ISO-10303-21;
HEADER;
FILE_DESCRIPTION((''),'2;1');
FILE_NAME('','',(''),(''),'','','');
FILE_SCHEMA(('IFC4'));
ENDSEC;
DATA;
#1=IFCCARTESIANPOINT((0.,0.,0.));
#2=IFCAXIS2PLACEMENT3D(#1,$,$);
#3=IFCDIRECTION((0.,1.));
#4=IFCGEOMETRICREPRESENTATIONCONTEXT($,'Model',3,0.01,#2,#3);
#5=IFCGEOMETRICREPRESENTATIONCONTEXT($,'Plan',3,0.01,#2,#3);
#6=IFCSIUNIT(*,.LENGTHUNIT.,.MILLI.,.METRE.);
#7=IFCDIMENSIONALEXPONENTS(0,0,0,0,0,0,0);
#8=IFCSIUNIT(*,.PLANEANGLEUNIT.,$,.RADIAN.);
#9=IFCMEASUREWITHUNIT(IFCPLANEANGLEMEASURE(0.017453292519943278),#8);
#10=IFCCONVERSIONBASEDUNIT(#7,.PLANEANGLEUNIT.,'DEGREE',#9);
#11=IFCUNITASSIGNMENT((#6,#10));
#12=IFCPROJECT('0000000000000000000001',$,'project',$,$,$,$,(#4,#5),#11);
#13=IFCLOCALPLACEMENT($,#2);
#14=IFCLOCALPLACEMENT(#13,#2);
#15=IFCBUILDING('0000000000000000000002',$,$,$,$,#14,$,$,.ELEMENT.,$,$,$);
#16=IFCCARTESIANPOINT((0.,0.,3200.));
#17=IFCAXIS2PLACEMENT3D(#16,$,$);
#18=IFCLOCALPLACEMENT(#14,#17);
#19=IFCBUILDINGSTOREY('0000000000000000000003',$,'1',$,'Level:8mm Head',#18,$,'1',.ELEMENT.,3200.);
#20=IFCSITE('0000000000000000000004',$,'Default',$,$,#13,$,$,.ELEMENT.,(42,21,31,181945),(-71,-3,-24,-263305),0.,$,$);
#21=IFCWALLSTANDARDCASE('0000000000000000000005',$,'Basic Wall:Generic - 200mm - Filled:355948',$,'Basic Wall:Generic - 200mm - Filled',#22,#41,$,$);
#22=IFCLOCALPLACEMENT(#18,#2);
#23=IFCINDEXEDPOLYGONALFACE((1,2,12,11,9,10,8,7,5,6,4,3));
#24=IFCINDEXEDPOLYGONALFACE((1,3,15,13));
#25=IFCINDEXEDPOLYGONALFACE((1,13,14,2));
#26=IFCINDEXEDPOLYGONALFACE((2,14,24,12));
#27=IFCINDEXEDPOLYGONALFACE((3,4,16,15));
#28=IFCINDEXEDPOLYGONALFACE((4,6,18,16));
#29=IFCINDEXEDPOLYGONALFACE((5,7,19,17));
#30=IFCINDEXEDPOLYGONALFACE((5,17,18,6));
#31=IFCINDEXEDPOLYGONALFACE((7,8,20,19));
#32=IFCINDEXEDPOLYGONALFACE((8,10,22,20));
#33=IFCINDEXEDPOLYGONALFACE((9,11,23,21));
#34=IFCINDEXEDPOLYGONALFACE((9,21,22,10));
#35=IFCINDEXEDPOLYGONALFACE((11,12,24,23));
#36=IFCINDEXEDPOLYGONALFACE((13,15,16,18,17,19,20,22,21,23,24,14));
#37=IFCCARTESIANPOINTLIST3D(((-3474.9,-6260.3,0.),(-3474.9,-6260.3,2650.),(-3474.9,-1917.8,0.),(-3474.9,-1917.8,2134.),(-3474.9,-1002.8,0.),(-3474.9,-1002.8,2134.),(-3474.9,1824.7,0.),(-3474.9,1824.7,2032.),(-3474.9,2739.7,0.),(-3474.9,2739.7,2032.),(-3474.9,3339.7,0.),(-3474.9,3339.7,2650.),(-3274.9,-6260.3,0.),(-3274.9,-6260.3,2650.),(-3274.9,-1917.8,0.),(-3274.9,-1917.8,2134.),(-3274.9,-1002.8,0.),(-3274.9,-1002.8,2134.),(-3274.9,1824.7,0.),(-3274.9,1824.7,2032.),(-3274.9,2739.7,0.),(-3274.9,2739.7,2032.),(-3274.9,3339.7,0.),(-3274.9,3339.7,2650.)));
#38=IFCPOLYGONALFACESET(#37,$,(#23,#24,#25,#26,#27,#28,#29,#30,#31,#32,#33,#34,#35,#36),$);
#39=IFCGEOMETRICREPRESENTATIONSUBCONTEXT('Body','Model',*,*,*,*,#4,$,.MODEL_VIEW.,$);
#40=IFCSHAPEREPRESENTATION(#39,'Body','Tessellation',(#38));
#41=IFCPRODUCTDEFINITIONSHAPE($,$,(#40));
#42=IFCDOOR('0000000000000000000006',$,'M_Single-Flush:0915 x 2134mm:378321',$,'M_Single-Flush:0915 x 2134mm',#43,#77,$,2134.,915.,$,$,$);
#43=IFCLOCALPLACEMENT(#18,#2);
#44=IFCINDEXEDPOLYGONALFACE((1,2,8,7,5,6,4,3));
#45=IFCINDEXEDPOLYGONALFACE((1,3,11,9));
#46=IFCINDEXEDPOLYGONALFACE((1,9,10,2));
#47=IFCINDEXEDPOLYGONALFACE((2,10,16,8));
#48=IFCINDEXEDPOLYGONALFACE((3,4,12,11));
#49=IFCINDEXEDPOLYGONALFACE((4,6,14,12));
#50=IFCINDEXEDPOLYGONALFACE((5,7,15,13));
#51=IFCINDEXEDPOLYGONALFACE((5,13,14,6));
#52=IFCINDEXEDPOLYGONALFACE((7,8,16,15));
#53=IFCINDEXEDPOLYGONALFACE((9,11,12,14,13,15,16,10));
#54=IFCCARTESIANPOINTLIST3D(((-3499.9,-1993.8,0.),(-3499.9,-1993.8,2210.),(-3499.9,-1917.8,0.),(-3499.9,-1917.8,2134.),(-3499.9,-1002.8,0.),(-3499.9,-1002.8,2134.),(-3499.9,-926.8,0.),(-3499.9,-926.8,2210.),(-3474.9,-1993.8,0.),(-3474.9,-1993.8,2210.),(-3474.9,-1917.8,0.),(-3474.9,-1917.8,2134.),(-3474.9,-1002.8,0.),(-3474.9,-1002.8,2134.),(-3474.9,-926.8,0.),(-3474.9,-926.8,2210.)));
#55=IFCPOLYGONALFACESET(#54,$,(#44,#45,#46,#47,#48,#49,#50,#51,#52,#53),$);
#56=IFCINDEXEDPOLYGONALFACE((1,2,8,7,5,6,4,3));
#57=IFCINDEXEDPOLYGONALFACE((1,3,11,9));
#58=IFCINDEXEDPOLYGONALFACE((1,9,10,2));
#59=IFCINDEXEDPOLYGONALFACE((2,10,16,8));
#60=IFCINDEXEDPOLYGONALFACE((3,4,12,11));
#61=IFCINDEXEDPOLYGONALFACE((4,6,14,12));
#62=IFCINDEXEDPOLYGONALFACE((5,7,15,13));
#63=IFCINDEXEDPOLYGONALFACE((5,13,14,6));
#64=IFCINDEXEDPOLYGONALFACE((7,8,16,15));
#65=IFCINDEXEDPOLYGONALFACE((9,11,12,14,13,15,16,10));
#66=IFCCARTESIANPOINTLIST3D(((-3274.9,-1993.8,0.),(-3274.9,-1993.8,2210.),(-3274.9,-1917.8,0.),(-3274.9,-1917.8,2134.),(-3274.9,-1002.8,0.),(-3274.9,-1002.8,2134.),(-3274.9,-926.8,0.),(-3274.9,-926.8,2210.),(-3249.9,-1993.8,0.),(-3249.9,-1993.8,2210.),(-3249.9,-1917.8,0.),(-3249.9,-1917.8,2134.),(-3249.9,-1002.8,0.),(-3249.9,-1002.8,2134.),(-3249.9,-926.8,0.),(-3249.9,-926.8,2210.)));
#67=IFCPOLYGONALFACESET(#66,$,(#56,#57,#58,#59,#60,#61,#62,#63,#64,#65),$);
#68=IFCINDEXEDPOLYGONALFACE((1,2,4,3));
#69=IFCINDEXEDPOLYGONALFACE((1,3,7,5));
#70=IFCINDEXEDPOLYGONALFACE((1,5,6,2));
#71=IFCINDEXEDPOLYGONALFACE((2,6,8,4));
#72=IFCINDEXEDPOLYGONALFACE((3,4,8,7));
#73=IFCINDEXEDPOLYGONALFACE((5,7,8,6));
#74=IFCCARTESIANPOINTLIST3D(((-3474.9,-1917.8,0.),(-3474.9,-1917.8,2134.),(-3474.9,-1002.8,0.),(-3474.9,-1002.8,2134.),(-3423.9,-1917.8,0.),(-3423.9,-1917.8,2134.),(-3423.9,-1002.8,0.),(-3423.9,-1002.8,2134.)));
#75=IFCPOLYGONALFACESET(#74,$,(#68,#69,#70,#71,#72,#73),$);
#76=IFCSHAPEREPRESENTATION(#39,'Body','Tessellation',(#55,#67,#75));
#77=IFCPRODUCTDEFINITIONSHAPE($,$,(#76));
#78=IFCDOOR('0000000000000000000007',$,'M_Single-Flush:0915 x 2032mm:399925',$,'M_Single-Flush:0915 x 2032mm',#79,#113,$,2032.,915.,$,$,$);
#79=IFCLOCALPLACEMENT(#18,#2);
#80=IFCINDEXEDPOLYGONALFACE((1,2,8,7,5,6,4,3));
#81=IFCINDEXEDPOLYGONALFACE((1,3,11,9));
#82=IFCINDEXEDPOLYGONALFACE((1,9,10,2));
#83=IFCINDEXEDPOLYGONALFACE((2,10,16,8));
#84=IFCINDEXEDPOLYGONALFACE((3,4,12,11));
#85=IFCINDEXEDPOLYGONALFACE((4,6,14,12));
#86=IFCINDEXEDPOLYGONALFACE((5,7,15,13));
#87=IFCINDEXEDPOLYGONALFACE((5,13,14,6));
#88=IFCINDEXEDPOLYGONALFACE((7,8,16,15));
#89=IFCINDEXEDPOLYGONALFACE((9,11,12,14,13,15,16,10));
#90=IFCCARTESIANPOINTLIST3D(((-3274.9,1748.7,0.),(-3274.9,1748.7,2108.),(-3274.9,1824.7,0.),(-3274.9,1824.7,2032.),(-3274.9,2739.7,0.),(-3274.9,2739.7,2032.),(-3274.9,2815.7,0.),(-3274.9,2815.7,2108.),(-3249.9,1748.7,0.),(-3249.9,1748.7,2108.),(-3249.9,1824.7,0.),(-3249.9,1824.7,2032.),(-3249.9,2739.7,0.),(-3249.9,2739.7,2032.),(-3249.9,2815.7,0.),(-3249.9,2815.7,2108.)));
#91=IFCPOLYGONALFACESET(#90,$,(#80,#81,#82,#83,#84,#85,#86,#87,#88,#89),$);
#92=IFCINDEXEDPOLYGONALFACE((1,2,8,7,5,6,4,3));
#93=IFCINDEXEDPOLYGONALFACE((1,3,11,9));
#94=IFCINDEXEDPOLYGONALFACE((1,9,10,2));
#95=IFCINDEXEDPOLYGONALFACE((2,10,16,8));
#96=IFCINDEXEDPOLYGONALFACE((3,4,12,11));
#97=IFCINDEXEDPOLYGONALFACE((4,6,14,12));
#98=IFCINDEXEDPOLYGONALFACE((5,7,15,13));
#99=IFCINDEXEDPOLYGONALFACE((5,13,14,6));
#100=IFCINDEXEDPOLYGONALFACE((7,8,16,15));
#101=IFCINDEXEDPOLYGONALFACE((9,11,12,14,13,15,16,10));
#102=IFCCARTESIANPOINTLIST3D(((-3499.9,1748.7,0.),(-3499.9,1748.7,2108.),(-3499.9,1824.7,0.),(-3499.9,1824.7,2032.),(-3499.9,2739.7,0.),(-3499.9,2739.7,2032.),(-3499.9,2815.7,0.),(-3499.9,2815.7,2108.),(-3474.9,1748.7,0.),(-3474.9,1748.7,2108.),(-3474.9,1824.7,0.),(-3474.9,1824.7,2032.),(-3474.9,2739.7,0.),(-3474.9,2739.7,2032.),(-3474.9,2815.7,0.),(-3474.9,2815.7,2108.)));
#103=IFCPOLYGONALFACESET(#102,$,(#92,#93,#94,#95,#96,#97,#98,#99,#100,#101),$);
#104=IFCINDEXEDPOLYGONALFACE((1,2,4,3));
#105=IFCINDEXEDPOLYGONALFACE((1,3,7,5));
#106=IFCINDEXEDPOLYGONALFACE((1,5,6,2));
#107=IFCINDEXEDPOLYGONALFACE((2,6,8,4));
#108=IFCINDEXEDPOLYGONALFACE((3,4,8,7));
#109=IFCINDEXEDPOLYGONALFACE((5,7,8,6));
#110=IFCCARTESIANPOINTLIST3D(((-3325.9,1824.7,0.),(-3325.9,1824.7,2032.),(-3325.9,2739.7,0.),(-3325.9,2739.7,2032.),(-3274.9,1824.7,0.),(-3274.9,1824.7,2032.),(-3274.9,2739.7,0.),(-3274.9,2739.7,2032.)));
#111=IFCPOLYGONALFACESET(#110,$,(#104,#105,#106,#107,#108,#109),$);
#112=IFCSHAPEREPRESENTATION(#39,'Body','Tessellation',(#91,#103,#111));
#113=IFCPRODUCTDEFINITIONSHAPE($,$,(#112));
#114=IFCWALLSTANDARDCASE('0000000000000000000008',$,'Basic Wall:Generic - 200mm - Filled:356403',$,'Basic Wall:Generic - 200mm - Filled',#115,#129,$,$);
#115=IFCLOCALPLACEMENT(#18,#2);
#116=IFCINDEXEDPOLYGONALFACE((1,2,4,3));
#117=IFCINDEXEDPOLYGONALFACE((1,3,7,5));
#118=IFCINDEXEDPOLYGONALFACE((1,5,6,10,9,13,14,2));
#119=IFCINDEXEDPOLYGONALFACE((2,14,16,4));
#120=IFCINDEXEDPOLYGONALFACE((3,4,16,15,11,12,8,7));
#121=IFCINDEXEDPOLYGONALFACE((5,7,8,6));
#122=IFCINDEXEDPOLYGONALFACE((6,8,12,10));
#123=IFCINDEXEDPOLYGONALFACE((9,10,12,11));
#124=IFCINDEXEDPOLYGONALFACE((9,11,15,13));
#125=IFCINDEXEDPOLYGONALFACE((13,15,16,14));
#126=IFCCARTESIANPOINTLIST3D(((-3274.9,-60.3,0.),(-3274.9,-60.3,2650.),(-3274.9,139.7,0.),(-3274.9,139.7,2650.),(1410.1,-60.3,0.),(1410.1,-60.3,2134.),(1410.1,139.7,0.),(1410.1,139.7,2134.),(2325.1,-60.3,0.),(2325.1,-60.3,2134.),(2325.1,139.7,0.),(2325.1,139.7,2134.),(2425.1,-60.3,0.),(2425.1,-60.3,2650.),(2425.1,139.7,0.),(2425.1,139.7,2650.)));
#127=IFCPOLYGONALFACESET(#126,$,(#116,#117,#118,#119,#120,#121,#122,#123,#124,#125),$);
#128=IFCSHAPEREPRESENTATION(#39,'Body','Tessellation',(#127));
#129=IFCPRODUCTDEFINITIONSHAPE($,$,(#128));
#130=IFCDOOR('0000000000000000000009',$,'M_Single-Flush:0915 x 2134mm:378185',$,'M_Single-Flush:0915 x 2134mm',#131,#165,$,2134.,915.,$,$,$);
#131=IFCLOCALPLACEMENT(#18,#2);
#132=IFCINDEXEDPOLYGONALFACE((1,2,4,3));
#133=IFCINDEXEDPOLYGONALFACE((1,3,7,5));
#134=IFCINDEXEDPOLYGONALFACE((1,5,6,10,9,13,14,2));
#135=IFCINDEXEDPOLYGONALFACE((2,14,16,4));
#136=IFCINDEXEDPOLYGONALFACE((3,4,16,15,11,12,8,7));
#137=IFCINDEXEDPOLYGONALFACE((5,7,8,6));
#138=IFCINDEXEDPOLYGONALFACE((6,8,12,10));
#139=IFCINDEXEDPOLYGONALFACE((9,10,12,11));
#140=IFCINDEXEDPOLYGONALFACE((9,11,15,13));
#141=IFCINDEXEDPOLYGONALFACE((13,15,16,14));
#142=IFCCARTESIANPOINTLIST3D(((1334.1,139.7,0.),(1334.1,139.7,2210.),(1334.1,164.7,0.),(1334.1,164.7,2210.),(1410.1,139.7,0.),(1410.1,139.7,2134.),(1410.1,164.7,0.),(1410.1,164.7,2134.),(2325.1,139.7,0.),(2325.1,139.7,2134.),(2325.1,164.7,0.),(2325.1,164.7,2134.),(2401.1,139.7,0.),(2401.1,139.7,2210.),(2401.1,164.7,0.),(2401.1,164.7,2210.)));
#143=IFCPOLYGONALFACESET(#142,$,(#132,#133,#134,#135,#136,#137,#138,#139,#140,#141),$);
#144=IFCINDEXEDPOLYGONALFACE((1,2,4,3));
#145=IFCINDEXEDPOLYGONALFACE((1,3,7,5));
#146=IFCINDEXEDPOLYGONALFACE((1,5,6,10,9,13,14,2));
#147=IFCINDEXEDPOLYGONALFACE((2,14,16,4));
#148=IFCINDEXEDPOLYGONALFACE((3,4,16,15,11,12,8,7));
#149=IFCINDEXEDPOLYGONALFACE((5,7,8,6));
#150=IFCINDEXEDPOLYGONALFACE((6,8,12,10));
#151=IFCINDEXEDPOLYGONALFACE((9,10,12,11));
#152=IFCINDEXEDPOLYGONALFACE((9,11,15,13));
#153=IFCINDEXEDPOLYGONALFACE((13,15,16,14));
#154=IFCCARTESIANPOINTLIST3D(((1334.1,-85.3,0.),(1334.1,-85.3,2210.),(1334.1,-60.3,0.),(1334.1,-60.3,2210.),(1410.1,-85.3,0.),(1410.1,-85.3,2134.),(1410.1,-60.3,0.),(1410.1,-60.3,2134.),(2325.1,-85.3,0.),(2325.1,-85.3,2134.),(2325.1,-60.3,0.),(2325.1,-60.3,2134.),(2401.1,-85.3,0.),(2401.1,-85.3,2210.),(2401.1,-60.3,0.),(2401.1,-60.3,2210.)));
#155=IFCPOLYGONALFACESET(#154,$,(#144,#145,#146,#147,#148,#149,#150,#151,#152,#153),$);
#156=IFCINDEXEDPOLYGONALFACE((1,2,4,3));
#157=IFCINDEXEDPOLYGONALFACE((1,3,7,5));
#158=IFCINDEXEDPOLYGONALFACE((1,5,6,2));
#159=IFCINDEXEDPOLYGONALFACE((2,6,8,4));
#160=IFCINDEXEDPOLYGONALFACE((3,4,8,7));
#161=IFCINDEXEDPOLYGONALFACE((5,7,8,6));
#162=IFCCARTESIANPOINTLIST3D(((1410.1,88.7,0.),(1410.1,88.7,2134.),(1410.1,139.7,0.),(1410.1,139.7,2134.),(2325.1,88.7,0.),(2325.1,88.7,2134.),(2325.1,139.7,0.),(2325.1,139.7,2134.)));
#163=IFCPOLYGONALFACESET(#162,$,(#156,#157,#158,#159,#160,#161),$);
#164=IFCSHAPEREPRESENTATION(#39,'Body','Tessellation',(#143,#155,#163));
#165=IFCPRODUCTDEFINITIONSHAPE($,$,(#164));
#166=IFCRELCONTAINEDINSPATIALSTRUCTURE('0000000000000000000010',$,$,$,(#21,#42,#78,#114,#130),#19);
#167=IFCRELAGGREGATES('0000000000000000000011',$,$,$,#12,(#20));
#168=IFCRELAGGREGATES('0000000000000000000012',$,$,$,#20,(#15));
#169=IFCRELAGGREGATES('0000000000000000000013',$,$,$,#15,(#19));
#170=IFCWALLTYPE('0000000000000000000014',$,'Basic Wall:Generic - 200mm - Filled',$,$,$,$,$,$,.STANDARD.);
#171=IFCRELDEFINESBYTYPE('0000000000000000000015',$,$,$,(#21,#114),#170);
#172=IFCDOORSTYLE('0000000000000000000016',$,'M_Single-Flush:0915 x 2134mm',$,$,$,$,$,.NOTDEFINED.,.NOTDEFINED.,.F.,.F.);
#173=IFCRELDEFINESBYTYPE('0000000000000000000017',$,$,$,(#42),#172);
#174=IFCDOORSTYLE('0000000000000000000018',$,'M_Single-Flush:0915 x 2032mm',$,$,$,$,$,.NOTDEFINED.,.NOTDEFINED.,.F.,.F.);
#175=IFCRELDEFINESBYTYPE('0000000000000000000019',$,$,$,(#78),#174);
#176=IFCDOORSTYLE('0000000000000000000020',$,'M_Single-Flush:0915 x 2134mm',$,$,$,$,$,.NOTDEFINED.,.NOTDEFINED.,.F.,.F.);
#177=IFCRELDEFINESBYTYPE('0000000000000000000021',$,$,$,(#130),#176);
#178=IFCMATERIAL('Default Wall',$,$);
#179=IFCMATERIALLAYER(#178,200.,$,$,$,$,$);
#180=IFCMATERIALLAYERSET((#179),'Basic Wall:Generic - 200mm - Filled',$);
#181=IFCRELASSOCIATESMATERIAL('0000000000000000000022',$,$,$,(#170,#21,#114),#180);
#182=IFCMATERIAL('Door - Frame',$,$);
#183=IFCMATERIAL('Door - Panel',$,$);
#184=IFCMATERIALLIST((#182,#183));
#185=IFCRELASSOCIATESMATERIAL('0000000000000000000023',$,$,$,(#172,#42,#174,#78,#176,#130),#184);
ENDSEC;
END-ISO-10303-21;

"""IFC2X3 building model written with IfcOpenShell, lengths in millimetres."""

from ifc_helpers import new_model, entity, si_unit, converted_unit, direction, frame, frame_2d, origin, place, context, subcontext, project, spatial, polyline, rectangle, outline, extrude, clip, bounded_halfspace, source, transform, mapped, material, material_list, layer, layer_set, layer_usage, type_object, type_shapes, element, fill, save


model = new_model("IFC2X3")

# Units and contexts
model_context = context("Model", 3, precision=0.01, world=origin(), true_north=direction((0.0, 1.0)))
plan_context = context("Plan", 3, precision=0.01, world=origin(), true_north=direction((0.0, 1.0)))
body_context = subcontext(model_context, "Body", "Model", "MODEL_VIEW")
ifc_project = project(units=[si_unit("LENGTHUNIT", "METRE", prefix="MILLI"), converted_unit("PLANEANGLEUNIT", "DEGREE", entity("IfcPlaneAngleMeasure", 0.017453292519943278), si_unit("PLANEANGLEUNIT", "RADIAN"), dimensions=[0, 0, 0, 0, 0, 0, 0])], contexts=[model_context, plan_context])

# Site, building, storey
site_placement = place(None, origin())
site = spatial("IfcSite", under=ifc_project, at=site_placement, Name="Default", CompositionType="ELEMENT", RefLatitude=(42, 21, 31, 181945), RefLongitude=(-71, -3, -24, -263305), RefElevation=0.0)
building_placement = place(site_placement, origin())
building = spatial("IfcBuilding", under=site, at=building_placement, CompositionType="ELEMENT")
storey_placement = place(building_placement, frame((0.0, 0.0, 3200.0)))
storey = spatial("IfcBuildingStorey", under=building, at=storey_placement, Name="1", ObjectType="Level:8mm Head", LongName="1", CompositionType="ELEMENT", Elevation=3200.0)

# Wall, openings, doors
ifc_material_1 = material(Name="Default Wall")
ifc_layer_1 = layer(ifc_material_1, 200.0)
ifc_layer_set_1 = layer_set([ifc_layer_1], Name="Basic Wall:Generic - 200mm - Filled")
ifc_layer_usage_1 = layer_usage(ifc_layer_set_1, "AXIS2", "NEGATIVE", 100.0)
wall_type_1 = type_object("IfcWallType", Name="Basic Wall:Generic - 200mm - Filled", PredefinedType="STANDARD", material=ifc_layer_set_1)
wall_1_placement = place(storey_placement, frame((-3374.9, 3339.7, 0.0), z_axis=(0.0, 0.0, 1.0), x_axis=(0.0, -1.0, 0.0)))
wall_1 = element("IfcWallStandardCase", 1, at=wall_1_placement, inside=storey, type_object=wall_type_1, material=ifc_layer_usage_1, Name="Basic Wall:Generic - 200mm - Filled:355948", ObjectType="Basic Wall:Generic - 200mm - Filled", context=body_context, shape_type="Clipping", body=[
    clip(extrude(rectangle(XDim=9600.0, YDim=200.0, at=frame_2d((4800.0, 0.0), x_axis=(-1.0, 0.0))), origin(), (0.0, 0.0, 1.0), 2650.0), bounded_halfspace(frame((6605.0, 100.0, 2650.0), z_axis=(0.0, 0.0, -1.0), x_axis=(1.0, 0.0, 0.0)), True, frame((6605.0, 100.0, 2650.0)), polyline([(0.0, 0.0), (-1000.0, 0.0), (-1200.0, 0.0), (-3205.0, 0.0), (-3405.0, 0.0), (-6605.0, 0.0), (-6605.0, -200.0), (0.0, -200.0), (2995.0, -200.0), (2995.0, -100.0), (0.0, -100.0), (0.0, 0.0)]))),
])
opening_1_placement = place(wall_1_placement, frame((5257.5, 100.0, 0.0)))
opening_1 = element("IfcOpeningElement", 2, at=opening_1_placement, cuts=wall_1, ObjectType="Opening", context=body_context, shape_type="SweptSolid", body=[
    extrude(rectangle(XDim=915.0, YDim=2134.0, at=frame_2d((1067.0, 457.5), x_axis=(0.0, 1.0))), frame((0.0, 0.0, 0.0), z_axis=(0.0, -1.0, 0.0), x_axis=(0.0, 0.0, 1.0)), (0.0, 0.0, 1.0), 200.0),
])
opening_2_placement = place(wall_1_placement, frame((600.0, -100.0, 0.0)))
opening_2 = element("IfcOpeningElement", 3, at=opening_2_placement, cuts=wall_1, ObjectType="Opening", context=body_context, shape_type="SweptSolid", body=[
    extrude(rectangle(XDim=915.0, YDim=2032.0, at=frame_2d((1016.0, 457.5), x_axis=(0.0, -1.0))), frame((0.0, 0.0, 0.0), z_axis=(0.0, 1.0, 0.0), x_axis=(0.0, 0.0, 1.0)), (0.0, 0.0, 1.0), 200.0),
])
ifc_material_2 = material(Name="Door - Frame")
ifc_material_3 = material(Name="Door - Panel")
ifc_material_list = material_list([ifc_material_2, ifc_material_3])
door_style_1 = type_object("IfcDoorStyle", Name="M_Single-Flush:0915 x 2134mm", ConstructionType="NOTDEFINED", OperationType="NOTDEFINED", ParameterTakesPrecedence=False, Sizeable=False, material=ifc_material_list)
shared_shape_1 = source(origin(), body_context, "Body", "SweptSolid", [
    extrude(outline(polyline([(-533.5, -1124.0), (533.5, -1124.0), (533.5, 1086.0), (457.5, 1086.0), (457.5, -1048.0), (-457.5, -1048.0), (-457.5, 1086.0), (-533.5, 1086.0), (-533.5, -1124.0)])), frame((457.5, 200.0, 1086.0), z_axis=(0.0, 1.0, 0.0), x_axis=(1.0, 0.0, 0.0)), (0.0, 0.0, 1.0), 25.0),
    extrude(outline(polyline([(-1124.0, -533.5), (1086.0, -533.5), (1086.0, -457.5), (-1048.0, -457.5), (-1048.0, 457.5), (1086.0, 457.5), (1086.0, 533.5), (-1124.0, 533.5), (-1124.0, -533.5)])), frame((457.5, -25.0, 1086.0), z_axis=(0.0, 1.0, 0.0), x_axis=(0.0, 0.0, -1.0)), (0.0, 0.0, 1.0), 25.0),
    extrude(rectangle(XDim=51.0, YDim=915.0, at=frame_2d((0.0, 0.0), x_axis=(1.0, 0.0))), frame((457.5, 174.5, 0.0), z_axis=(0.0, 0.0, 1.0), x_axis=(0.0, 1.0, 0.0)), (0.0, 0.0, 1.0), 2134.0),
])
type_shapes(door_style_1, [shared_shape_1])
door_1_placement = place(opening_1_placement, frame((0.0, 0.0, 0.0), z_axis=(0.0, 0.0, 1.0), x_axis=(-1.0, 0.0, 0.0)))
door_1 = element("IfcDoor", 4, at=door_1_placement, inside=storey, type_object=door_style_1, material=ifc_material_list, Name="M_Single-Flush:0915 x 2134mm:378321", ObjectType="M_Single-Flush:0915 x 2134mm", OverallHeight=2134.0, OverallWidth=915.0, context=body_context, shape_type="MappedRepresentation", body=[
    mapped(shared_shape_1, transform((0.0, 0.0, 0.0), scale=1.0)),
])
fill(opening_1, door_1)
door_style_2 = type_object("IfcDoorStyle", Name="M_Single-Flush:0915 x 2032mm", ConstructionType="NOTDEFINED", OperationType="NOTDEFINED", ParameterTakesPrecedence=False, Sizeable=False, material=ifc_material_list)
shared_shape_2 = source(origin(), body_context, "Body", "SweptSolid", [
    extrude(outline(polyline([(-533.5, -1073.0), (533.5, -1073.0), (533.5, 1035.0), (457.5, 1035.0), (457.5, -997.0), (-457.5, -997.0), (-457.5, 1035.0), (-533.5, 1035.0), (-533.5, -1073.0)])), frame((457.5, 225.0, 1035.0), z_axis=(0.0, -1.0, 0.0), x_axis=(-1.0, 0.0, 0.0)), (0.0, 0.0, 1.0), 25.0),
    extrude(outline(polyline([(-1073.0, -533.5), (1035.0, -533.5), (1035.0, -457.5), (-997.0, -457.5), (-997.0, 457.5), (1035.0, 457.5), (1035.0, 533.5), (-1073.0, 533.5), (-1073.0, -533.5)])), frame((457.5, 0.0, 1035.0), z_axis=(0.0, -1.0, 0.0), x_axis=(0.0, 0.0, -1.0)), (0.0, 0.0, 1.0), 25.0),
    extrude(rectangle(XDim=915.0, YDim=51.0, at=frame_2d((0.0, 0.0), x_axis=(1.0, 0.0))), frame((457.5, 174.5, 0.0)), (0.0, 0.0, 1.0), 2032.0),
])
type_shapes(door_style_2, [shared_shape_2])
door_2_placement = place(opening_2_placement, origin())
door_2 = element("IfcDoor", 5, at=door_2_placement, inside=storey, type_object=door_style_2, material=ifc_material_list, Name="M_Single-Flush:0915 x 2032mm:399925", ObjectType="M_Single-Flush:0915 x 2032mm", OverallHeight=2032.0, OverallWidth=915.0, context=body_context, shape_type="MappedRepresentation", body=[
    mapped(shared_shape_2, transform((0.0, 0.0, 0.0), scale=1.0)),
])
fill(opening_2, door_2)

# Wall, opening, door
wall_2_placement = place(storey_placement, frame((-3274.9, 39.7, 0.0)))
wall_2 = element("IfcWallStandardCase", 6, at=wall_2_placement, inside=storey, type_object=wall_type_1, material=ifc_layer_usage_1, Name="Basic Wall:Generic - 200mm - Filled:356403", ObjectType="Basic Wall:Generic - 200mm - Filled", context=body_context, shape_type="Clipping", body=[
    clip(extrude(rectangle(XDim=5700.0, YDim=200.0, at=frame_2d((2850.0, 0.0), x_axis=(1.0, 0.0))), origin(), (0.0, 0.0, 1.0), 2650.0), bounded_halfspace(frame((0.0, -100.0, 2650.0), z_axis=(0.0, 0.0, -1.0), x_axis=(0.0, -1.0, 0.0)), True, frame((0.0, -100.0, 2650.0)), polyline([(0.0, 0.0), (5700.0, 0.0), (5700.0, 200.0), (4600.0, 200.0), (4500.0, 200.0), (2500.0, 200.0), (2300.0, 200.0), (0.0, 200.0), (0.0, 0.0)]))),
])
opening_3_placement = place(wall_2_placement, frame((4685.0, -100.0, 0.0)))
opening_3 = element("IfcOpeningElement", 7, at=opening_3_placement, cuts=wall_2, ObjectType="Opening", context=body_context, shape_type="SweptSolid", body=[
    extrude(rectangle(XDim=915.0, YDim=2134.0, at=frame_2d((1067.0, 457.5), x_axis=(0.0, -1.0))), frame((0.0, 0.0, 0.0), z_axis=(0.0, 1.0, 0.0), x_axis=(0.0, 0.0, 1.0)), (0.0, 0.0, 1.0), 200.0),
])
door_style_3 = type_object("IfcDoorStyle", Name="M_Single-Flush:0915 x 2134mm", ConstructionType="NOTDEFINED", OperationType="NOTDEFINED", ParameterTakesPrecedence=False, Sizeable=False, material=ifc_material_list)
shared_shape_3 = source(origin(), body_context, "Body", "SweptSolid", [
    extrude(outline(polyline([(-533.5, -1124.0), (533.5, -1124.0), (533.5, 1086.0), (457.5, 1086.0), (457.5, -1048.0), (-457.5, -1048.0), (-457.5, 1086.0), (-533.5, 1086.0), (-533.5, -1124.0)])), frame((457.5, 225.0, 1086.0), z_axis=(0.0, -1.0, 0.0), x_axis=(-1.0, 0.0, 0.0)), (0.0, 0.0, 1.0), 25.0),
    extrude(outline(polyline([(-1124.0, -533.5), (1086.0, -533.5), (1086.0, -457.5), (-1048.0, -457.5), (-1048.0, 457.5), (1086.0, 457.5), (1086.0, 533.5), (-1124.0, 533.5), (-1124.0, -533.5)])), frame((457.5, 0.0, 1086.0), z_axis=(0.0, -1.0, 0.0), x_axis=(0.0, 0.0, -1.0)), (0.0, 0.0, 1.0), 25.0),
    extrude(rectangle(XDim=915.0, YDim=51.0, at=frame_2d((0.0, 0.0), x_axis=(1.0, 0.0))), frame((457.5, 174.5, 0.0)), (0.0, 0.0, 1.0), 2134.0),
])
type_shapes(door_style_3, [shared_shape_3])
door_3_placement = place(opening_3_placement, origin())
door_3 = element("IfcDoor", 8, at=door_3_placement, inside=storey, type_object=door_style_3, material=ifc_material_list, Name="M_Single-Flush:0915 x 2134mm:378185", ObjectType="M_Single-Flush:0915 x 2134mm", OverallHeight=2134.0, OverallWidth=915.0, context=body_context, shape_type="MappedRepresentation", body=[
    mapped(shared_shape_3, transform((0.0, 0.0, 0.0), scale=1.0)),
])
fill(opening_3, door_3)

save(model, "model.ifc")
